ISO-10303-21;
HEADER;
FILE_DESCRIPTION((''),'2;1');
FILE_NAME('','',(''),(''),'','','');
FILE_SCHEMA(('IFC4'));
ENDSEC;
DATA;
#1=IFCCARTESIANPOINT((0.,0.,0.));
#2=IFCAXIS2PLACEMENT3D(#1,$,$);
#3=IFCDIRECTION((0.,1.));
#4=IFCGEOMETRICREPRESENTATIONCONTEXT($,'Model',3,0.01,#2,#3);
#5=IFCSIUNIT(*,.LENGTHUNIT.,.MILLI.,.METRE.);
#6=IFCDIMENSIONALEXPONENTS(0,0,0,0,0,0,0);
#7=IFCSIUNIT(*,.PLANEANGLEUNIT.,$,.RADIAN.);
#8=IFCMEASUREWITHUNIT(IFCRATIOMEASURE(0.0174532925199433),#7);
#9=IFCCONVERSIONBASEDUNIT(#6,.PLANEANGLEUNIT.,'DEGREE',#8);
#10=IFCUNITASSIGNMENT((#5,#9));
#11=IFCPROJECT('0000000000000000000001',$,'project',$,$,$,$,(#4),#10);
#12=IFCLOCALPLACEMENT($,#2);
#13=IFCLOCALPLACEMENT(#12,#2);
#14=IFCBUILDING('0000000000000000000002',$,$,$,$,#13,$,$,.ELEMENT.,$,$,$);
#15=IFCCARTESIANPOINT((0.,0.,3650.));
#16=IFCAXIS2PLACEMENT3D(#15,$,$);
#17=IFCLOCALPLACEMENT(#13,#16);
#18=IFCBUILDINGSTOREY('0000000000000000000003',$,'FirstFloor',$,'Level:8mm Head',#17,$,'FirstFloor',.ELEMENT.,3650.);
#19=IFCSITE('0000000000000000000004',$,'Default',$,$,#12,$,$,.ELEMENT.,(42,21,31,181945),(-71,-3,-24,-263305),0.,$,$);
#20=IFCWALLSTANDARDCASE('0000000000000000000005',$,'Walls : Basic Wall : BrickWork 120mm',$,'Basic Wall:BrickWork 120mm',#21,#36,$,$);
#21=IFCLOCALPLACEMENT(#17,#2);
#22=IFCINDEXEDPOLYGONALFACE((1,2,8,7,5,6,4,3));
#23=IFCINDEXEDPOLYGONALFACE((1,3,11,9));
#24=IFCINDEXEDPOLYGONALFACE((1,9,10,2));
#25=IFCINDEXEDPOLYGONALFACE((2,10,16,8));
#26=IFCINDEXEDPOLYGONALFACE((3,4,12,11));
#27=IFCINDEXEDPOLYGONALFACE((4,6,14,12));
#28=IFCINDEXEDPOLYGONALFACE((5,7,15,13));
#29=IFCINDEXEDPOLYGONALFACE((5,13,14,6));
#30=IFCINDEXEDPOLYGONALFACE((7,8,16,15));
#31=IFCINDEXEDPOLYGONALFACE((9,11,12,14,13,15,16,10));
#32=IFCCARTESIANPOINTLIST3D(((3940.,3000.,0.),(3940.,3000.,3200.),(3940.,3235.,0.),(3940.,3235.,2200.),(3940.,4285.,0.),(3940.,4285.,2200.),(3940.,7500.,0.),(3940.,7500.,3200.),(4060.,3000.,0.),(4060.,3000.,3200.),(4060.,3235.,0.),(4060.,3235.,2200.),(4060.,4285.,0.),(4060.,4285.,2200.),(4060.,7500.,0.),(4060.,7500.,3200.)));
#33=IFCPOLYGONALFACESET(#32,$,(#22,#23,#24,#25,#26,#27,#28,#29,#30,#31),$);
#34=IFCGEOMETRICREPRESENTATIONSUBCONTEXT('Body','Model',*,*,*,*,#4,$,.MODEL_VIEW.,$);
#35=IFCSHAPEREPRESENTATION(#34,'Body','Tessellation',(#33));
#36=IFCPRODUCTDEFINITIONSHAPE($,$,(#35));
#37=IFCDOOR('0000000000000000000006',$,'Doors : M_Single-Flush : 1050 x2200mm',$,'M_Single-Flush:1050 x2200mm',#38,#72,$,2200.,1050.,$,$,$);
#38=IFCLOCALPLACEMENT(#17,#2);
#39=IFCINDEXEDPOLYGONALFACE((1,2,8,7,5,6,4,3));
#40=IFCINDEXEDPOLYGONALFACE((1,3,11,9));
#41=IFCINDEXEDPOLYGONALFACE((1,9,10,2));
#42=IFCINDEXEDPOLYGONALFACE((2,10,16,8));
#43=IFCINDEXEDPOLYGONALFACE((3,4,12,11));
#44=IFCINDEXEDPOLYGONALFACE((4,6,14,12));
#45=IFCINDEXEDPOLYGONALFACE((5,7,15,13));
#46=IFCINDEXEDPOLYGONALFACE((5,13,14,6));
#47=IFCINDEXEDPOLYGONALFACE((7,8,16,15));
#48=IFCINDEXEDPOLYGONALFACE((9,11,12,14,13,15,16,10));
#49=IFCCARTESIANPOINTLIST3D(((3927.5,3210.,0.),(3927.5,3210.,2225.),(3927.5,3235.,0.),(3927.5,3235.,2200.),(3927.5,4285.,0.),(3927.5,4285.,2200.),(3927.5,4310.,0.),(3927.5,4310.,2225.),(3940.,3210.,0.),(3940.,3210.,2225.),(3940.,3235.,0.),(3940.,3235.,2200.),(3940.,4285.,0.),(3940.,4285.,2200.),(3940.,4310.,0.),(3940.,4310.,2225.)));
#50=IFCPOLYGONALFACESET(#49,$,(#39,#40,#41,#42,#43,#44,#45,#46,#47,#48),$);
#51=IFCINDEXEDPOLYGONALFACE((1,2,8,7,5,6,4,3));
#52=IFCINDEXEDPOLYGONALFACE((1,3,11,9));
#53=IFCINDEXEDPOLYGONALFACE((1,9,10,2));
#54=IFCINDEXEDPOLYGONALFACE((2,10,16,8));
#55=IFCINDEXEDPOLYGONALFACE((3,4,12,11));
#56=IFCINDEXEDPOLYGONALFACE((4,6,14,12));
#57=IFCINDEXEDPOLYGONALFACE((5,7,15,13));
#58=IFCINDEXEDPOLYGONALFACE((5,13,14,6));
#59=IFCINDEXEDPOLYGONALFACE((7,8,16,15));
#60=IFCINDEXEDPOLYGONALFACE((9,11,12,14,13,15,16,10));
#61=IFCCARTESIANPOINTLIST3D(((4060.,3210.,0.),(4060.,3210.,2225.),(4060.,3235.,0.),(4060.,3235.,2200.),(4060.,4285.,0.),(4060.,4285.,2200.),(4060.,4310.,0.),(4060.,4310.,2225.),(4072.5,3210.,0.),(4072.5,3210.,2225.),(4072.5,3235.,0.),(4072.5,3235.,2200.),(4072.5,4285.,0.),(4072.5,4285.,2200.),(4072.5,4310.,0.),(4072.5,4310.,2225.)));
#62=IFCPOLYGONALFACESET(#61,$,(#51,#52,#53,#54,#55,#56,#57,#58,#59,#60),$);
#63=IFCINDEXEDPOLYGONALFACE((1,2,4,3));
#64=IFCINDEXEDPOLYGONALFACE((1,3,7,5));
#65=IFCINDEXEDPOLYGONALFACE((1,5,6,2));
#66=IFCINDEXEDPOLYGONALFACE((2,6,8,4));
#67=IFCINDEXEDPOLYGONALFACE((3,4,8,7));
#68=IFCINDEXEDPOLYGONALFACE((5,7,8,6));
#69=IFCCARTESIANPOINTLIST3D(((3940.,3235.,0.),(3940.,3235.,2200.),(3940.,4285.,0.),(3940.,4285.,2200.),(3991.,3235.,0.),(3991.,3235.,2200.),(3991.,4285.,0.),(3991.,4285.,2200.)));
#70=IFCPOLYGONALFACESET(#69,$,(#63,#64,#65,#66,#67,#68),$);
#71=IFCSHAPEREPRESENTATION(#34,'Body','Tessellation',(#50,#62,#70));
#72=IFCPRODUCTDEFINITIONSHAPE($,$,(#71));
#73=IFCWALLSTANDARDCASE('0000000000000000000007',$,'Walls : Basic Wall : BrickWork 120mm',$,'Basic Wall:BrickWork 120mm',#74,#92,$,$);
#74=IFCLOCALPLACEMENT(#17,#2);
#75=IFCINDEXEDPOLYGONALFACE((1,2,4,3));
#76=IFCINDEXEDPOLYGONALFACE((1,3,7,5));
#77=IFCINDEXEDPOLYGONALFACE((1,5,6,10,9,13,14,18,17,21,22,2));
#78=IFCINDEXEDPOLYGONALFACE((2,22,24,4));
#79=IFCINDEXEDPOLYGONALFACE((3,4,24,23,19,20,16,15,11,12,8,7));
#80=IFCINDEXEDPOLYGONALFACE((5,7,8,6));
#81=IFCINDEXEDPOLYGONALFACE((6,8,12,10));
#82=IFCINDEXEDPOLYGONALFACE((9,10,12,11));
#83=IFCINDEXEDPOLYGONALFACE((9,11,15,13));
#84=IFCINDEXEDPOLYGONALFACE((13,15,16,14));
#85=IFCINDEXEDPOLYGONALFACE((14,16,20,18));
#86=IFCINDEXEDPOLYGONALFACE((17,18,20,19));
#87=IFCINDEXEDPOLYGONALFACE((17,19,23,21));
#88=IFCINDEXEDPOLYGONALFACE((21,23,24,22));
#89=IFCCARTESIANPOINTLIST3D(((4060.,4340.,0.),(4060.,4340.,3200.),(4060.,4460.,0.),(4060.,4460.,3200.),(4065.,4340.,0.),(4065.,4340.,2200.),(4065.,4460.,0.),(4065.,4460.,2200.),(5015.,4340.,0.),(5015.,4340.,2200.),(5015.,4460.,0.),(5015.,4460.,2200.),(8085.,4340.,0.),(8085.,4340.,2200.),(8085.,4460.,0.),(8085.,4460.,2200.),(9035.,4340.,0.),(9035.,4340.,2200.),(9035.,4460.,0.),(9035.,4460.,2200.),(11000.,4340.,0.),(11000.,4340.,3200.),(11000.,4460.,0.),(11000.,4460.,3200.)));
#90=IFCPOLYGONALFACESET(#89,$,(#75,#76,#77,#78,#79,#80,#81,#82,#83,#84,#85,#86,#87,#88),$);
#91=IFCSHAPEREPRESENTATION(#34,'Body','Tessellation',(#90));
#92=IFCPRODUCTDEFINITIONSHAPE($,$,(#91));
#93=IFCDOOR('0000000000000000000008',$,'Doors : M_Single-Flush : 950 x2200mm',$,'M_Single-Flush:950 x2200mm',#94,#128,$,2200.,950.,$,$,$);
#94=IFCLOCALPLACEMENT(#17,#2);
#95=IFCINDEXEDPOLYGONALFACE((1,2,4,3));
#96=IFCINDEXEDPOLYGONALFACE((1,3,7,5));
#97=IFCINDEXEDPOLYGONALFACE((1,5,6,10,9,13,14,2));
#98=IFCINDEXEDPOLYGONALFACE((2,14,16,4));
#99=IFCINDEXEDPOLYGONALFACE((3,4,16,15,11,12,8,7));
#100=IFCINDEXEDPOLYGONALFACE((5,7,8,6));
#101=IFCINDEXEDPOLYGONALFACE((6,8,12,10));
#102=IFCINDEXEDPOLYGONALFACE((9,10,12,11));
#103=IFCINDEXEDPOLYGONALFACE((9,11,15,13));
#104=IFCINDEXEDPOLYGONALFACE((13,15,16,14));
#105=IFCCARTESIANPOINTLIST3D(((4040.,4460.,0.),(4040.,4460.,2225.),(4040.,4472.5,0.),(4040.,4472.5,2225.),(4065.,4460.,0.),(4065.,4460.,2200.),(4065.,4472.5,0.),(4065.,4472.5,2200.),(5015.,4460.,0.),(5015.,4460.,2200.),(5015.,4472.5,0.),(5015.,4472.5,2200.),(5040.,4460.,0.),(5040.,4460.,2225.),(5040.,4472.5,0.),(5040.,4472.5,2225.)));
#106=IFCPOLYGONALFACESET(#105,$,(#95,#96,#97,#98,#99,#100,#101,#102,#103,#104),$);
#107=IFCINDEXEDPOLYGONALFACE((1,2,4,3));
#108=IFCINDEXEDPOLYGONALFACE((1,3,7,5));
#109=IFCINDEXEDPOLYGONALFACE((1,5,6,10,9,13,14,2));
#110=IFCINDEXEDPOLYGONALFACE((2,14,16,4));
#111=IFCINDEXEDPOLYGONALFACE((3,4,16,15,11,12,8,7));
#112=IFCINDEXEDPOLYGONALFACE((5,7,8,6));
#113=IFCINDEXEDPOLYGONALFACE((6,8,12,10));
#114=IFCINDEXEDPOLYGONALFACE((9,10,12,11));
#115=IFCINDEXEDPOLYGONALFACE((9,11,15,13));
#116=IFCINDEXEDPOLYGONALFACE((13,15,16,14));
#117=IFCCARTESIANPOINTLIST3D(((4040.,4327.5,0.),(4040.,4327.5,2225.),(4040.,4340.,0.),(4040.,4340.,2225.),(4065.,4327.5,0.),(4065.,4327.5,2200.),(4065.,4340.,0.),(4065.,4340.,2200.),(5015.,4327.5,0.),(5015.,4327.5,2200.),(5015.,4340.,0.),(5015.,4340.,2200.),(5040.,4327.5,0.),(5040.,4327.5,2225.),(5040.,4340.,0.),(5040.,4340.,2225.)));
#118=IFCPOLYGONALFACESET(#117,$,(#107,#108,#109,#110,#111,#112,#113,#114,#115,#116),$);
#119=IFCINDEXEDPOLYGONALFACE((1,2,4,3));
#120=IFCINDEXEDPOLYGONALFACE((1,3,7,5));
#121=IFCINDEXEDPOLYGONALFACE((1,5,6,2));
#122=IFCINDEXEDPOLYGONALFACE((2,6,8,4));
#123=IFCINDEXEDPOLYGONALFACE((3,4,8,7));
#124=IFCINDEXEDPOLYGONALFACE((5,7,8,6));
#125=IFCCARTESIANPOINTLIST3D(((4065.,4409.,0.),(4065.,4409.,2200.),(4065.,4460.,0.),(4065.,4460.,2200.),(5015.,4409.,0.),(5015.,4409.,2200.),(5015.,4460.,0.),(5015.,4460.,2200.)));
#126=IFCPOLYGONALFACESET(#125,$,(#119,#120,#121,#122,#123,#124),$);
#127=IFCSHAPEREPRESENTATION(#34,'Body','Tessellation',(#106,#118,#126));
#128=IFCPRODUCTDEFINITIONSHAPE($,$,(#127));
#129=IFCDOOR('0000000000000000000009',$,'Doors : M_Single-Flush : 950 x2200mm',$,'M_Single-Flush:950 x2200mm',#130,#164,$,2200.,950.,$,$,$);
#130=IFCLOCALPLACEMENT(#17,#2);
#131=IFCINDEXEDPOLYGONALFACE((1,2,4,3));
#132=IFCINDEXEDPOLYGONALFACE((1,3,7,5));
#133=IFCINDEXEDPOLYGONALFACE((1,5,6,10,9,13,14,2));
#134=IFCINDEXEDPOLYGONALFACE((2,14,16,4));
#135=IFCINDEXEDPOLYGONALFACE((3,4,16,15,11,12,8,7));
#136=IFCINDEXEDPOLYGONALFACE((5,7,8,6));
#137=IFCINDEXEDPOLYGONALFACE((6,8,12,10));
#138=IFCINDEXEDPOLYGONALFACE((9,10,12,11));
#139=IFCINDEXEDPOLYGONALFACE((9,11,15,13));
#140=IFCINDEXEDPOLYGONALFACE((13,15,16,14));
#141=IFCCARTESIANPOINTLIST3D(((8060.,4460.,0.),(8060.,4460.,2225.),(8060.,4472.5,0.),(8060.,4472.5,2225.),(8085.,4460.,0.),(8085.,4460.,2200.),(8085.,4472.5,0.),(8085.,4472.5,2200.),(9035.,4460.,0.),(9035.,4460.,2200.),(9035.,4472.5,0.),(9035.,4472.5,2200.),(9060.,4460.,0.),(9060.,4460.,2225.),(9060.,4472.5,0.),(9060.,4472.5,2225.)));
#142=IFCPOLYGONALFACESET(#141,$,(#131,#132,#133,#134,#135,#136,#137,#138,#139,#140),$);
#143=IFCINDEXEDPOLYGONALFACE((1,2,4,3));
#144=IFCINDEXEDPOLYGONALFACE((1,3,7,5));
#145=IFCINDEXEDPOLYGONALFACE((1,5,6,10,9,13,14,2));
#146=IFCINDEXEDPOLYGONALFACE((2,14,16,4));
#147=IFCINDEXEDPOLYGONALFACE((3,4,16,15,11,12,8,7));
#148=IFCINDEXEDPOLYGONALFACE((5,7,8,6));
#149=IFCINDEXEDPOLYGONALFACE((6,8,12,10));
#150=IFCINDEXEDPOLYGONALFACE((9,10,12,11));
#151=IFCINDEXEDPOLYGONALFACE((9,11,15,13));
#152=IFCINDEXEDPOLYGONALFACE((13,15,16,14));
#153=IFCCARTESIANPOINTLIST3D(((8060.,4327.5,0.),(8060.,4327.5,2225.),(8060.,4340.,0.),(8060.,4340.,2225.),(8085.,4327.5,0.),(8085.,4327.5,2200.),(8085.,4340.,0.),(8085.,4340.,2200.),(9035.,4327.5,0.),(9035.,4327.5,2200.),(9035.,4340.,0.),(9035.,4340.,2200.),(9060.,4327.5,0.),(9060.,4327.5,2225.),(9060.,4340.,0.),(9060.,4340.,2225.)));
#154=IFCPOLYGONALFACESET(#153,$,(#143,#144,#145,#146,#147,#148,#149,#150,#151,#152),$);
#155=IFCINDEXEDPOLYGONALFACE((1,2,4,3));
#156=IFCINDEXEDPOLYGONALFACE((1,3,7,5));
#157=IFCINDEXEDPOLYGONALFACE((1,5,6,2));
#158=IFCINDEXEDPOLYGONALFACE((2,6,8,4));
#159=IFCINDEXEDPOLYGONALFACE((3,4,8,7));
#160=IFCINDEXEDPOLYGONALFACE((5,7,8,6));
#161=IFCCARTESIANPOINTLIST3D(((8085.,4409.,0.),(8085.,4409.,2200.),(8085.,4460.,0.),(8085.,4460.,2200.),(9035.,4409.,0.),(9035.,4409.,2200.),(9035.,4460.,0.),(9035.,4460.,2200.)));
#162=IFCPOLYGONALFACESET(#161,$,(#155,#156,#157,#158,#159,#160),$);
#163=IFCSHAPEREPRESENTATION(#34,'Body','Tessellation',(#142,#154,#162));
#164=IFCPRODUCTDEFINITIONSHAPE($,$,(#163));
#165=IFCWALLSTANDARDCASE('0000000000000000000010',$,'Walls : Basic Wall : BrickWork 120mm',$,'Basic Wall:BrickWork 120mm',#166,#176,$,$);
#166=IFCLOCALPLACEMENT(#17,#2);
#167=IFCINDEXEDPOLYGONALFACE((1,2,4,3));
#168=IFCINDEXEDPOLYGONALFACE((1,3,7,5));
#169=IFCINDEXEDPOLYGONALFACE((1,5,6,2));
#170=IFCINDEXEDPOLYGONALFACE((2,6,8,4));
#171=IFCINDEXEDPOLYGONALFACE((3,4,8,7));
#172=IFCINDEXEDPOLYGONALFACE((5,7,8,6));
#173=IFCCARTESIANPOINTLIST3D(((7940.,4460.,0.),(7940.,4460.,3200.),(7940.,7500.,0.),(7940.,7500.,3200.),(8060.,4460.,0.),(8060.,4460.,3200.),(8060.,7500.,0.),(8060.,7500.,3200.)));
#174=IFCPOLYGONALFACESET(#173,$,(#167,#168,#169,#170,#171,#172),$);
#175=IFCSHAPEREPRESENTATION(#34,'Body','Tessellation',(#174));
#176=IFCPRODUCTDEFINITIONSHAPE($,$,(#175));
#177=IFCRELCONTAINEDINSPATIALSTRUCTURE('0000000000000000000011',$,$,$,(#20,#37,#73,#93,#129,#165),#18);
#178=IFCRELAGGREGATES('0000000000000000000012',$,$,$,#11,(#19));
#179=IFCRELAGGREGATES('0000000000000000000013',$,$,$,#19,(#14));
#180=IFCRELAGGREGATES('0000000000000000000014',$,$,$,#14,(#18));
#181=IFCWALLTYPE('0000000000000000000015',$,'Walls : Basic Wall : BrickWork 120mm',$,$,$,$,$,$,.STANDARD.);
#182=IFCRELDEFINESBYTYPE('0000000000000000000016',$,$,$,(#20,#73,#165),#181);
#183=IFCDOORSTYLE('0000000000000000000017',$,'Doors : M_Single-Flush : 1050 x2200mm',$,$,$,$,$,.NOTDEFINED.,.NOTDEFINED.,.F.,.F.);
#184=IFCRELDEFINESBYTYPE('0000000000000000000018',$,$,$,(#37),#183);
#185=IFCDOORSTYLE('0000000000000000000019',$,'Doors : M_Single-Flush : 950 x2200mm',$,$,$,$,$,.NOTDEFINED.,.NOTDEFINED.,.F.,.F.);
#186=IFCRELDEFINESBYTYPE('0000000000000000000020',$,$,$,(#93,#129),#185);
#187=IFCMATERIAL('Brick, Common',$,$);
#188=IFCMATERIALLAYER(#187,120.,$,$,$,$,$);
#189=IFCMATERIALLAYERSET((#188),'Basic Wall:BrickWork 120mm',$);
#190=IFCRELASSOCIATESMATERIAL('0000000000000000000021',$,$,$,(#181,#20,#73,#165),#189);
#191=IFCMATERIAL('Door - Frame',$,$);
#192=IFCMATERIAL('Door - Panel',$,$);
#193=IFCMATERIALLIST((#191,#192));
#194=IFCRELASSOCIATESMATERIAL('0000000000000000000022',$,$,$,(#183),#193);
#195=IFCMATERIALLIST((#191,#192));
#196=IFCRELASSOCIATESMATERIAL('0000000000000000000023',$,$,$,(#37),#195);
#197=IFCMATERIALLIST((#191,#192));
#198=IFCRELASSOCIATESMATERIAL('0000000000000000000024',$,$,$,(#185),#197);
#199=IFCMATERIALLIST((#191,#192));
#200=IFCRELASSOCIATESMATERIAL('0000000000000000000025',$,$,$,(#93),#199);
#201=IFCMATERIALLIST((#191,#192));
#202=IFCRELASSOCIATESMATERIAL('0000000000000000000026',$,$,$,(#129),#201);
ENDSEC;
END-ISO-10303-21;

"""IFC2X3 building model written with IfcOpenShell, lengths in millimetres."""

from ifc_helpers import new_model, entity, si_unit, converted_unit, direction, frame, frame_2d, origin, place, context, subcontext, project, spatial, polyline, rectangle, outline, extrude, source, transform, mapped, material, material_list, layer, layer_set, layer_usage, type_object, type_shapes, element, fill, save


model = new_model("IFC2X3")

# Units and contexts
model_context = context("Model", 3, precision=0.01, world=origin(), true_north=direction((0.0, 1.0)))
body_context = subcontext(model_context, "Body", "Model", "MODEL_VIEW")
ifc_project = project(units=[si_unit("LENGTHUNIT", "METRE", prefix="MILLI"), converted_unit("PLANEANGLEUNIT", "DEGREE", entity("IfcRatioMeasure", 0.0174532925199433), si_unit("PLANEANGLEUNIT", "RADIAN"), dimensions=[0, 0, 0, 0, 0, 0, 0])], contexts=[model_context])

# Site, building, storey
site_placement = place(None, origin())
site = spatial("IfcSite", under=ifc_project, at=site_placement, Name="Default", CompositionType="ELEMENT", RefLatitude=(42, 21, 31, 181945), RefLongitude=(-71, -3, -24, -263305), RefElevation=0.0)
building_placement = place(site_placement, origin())
building = spatial("IfcBuilding", under=site, at=building_placement, CompositionType="ELEMENT")
storey_placement = place(building_placement, frame((0.0, 0.0, 3650.0)))
storey = spatial("IfcBuildingStorey", under=building, at=storey_placement, Name="FirstFloor", ObjectType="Level:8mm Head", LongName="FirstFloor", CompositionType="ELEMENT", Elevation=3650.0)

# Wall, opening, door
ifc_material_1 = material(Name="Brick, Common")
ifc_layer_1 = layer(ifc_material_1, 120.0)
ifc_layer_set_1 = layer_set([ifc_layer_1], Name="Basic Wall:BrickWork 120mm")
ifc_layer_usage_1 = layer_usage(ifc_layer_set_1, "AXIS2", "NEGATIVE", 60.0)
wall_type = type_object("IfcWallType", Name="Walls : Basic Wall : BrickWork 120mm", PredefinedType="STANDARD", material=ifc_layer_set_1)
wall_1_placement = place(storey_placement, frame((4000.0, 7500.0, 0.0), z_axis=(0.0, 0.0, 1.0), x_axis=(0.0, -1.0, 0.0)))
wall_1 = element("IfcWallStandardCase", 1, at=wall_1_placement, inside=storey, type_object=wall_type, material=ifc_layer_usage_1, Name="Walls : Basic Wall : BrickWork 120mm", ObjectType="Basic Wall:BrickWork 120mm", context=body_context, shape_type="SweptSolid", body=[
    extrude(rectangle(XDim=4500.0, YDim=120.0, at=frame_2d((2250.0, 0.0), x_axis=(-1.0, 0.0))), origin(), (0.0, 0.0, 1.0), 3200.0),
])
opening_1_placement = place(wall_1_placement, frame((4265.0, 60.0, 0.0)))
opening_1 = element("IfcOpeningElement", 2, at=opening_1_placement, cuts=wall_1, ObjectType="Opening", context=body_context, shape_type="SweptSolid", body=[
    extrude(rectangle(XDim=1050.0, YDim=2200.0, at=frame_2d((1100.0, 525.0), x_axis=(0.0, -1.0))), frame((0.0, 0.0, 0.0), z_axis=(0.0, -1.0, 0.0), x_axis=(0.0, 0.0, 1.0)), (0.0, 0.0, 1.0), 120.0),
])
ifc_material_2 = material(Name="Door - Frame")
ifc_material_3 = material(Name="Door - Panel")
ifc_material_list_1 = material_list([ifc_material_2, ifc_material_3])
ifc_material_list_2 = material_list([ifc_material_2, ifc_material_3])
door_style_1 = type_object("IfcDoorStyle", Name="Doors : M_Single-Flush : 1050 x2200mm", ConstructionType="NOTDEFINED", OperationType="NOTDEFINED", ParameterTakesPrecedence=False, Sizeable=False, material=ifc_material_list_2)
shared_shape_1 = source(origin(), body_context, "Body", "SweptSolid", [
    extrude(outline(polyline([(-550.0, -1118.8), (550.0, -1118.8), (550.0, 1106.2), (525.0, 1106.2), (525.0, -1093.8), (-525.0, -1093.8), (-525.0, 1106.2), (-550.0, 1106.2), (-550.0, -1118.8)])), frame((525.0, 132.5, 1106.2), z_axis=(0.0, -1.0, 0.0), x_axis=(-1.0, 0.0, 0.0)), (0.0, 0.0, 1.0), 12.5),
    extrude(outline(polyline([(-1118.8, -550.0), (1106.2, -550.0), (1106.2, -525.0), (-1093.8, -525.0), (-1093.8, 525.0), (1106.2, 525.0), (1106.2, 550.0), (-1118.8, 550.0), (-1118.8, -550.0)])), frame((525.0, 0.0, 1106.2), z_axis=(0.0, -1.0, 0.0), x_axis=(0.0, 0.0, -1.0)), (0.0, 0.0, 1.0), 12.5),
    extrude(rectangle(XDim=1050.0, YDim=51.0, at=frame_2d((0.0, 0.0), x_axis=(1.0, 0.0))), frame((525.0, 94.5, 0.0)), (0.0, 0.0, 1.0), 2200.0),
])
type_shapes(door_style_1, [shared_shape_1])
door_1_placement = place(opening_1_placement, frame((0.0, 0.0, 0.0), z_axis=(0.0, 0.0, 1.0), x_axis=(-1.0, 0.0, 0.0)))
door_1 = element("IfcDoor", 3, at=door_1_placement, inside=storey, type_object=door_style_1, material=ifc_material_list_1, Name="Doors : M_Single-Flush : 1050 x2200mm", ObjectType="M_Single-Flush:1050 x2200mm", OverallHeight=2200.0, OverallWidth=1050.0, context=body_context, shape_type="MappedRepresentation", body=[
    mapped(shared_shape_1, transform((0.0, 0.0, 0.0), scale=1.0)),
])
fill(opening_1, door_1)

# Wall, openings, doors
ifc_layer_usage_2 = layer_usage(ifc_layer_set_1, "AXIS2", "NEGATIVE", 60.0)
wall_2_placement = place(storey_placement, frame((11000.0, 4400.0, 0.0), z_axis=(0.0, 0.0, 1.0), x_axis=(-1.0, 0.0, 0.0)))
wall_2 = element("IfcWallStandardCase", 4, at=wall_2_placement, inside=storey, type_object=wall_type, material=ifc_layer_usage_2, Name="Walls : Basic Wall : BrickWork 120mm", ObjectType="Basic Wall:BrickWork 120mm", context=body_context, shape_type="SweptSolid", body=[
    extrude(rectangle(XDim=6940.0, YDim=120.0, at=frame_2d((3470.0, 0.0), x_axis=(-1.0, 0.0))), origin(), (0.0, 0.0, 1.0), 3200.0),
])
opening_2_placement = place(wall_2_placement, frame((6935.0, 60.0, 0.0)))
opening_2 = element("IfcOpeningElement", 5, at=opening_2_placement, cuts=wall_2, ObjectType="Opening", context=body_context, shape_type="SweptSolid", body=[
    extrude(rectangle(XDim=950.0, YDim=2200.0, at=frame_2d((1100.0, 475.0), x_axis=(0.0, -1.0))), frame((0.0, 0.0, 0.0), z_axis=(0.0, -1.0, 0.0), x_axis=(0.0, 0.0, 1.0)), (0.0, 0.0, 1.0), 120.0),
])
opening_3_placement = place(wall_2_placement, frame((2915.0, 60.0, 0.0)))
opening_3 = element("IfcOpeningElement", 6, at=opening_3_placement, cuts=wall_2, ObjectType="Opening", context=body_context, shape_type="SweptSolid", body=[
    extrude(rectangle(XDim=950.0, YDim=2200.0, at=frame_2d((1100.0, 475.0), x_axis=(0.0, -1.0))), frame((0.0, 0.0, 0.0), z_axis=(0.0, -1.0, 0.0), x_axis=(0.0, 0.0, 1.0)), (0.0, 0.0, 1.0), 120.0),
])
ifc_material_list_3 = material_list([ifc_material_2, ifc_material_3])
ifc_material_list_4 = material_list([ifc_material_2, ifc_material_3])
door_style_2 = type_object("IfcDoorStyle", Name="Doors : M_Single-Flush : 950 x2200mm", ConstructionType="NOTDEFINED", OperationType="NOTDEFINED", ParameterTakesPrecedence=False, Sizeable=False, material=ifc_material_list_4)
shared_shape_2 = source(origin(), body_context, "Body", "SweptSolid", [
    extrude(outline(polyline([(-500.0, -1118.8), (500.0, -1118.8), (500.0, 1106.2), (475.0, 1106.2), (475.0, -1093.8), (-475.0, -1093.8), (-475.0, 1106.2), (-500.0, 1106.2), (-500.0, -1118.8)])), frame((475.0, 132.5, 1106.2), z_axis=(0.0, -1.0, 0.0), x_axis=(-1.0, 0.0, 0.0)), (0.0, 0.0, 1.0), 12.5),
    extrude(outline(polyline([(-1118.8, -500.0), (1106.2, -500.0), (1106.2, -475.0), (-1093.8, -475.0), (-1093.8, 475.0), (1106.2, 475.0), (1106.2, 500.0), (-1118.8, 500.0), (-1118.8, -500.0)])), frame((475.0, 0.0, 1106.2), z_axis=(0.0, -1.0, 0.0), x_axis=(0.0, 0.0, -1.0)), (0.0, 0.0, 1.0), 12.5),
    extrude(rectangle(XDim=950.0, YDim=51.0, at=frame_2d((0.0, 0.0), x_axis=(1.0, 0.0))), frame((475.0, 94.5, 0.0)), (0.0, 0.0, 1.0), 2200.0),
])
type_shapes(door_style_2, [shared_shape_2])
door_2_placement = place(opening_2_placement, frame((0.0, 0.0, 0.0), z_axis=(0.0, 0.0, 1.0), x_axis=(-1.0, 0.0, 0.0)))
door_2 = element("IfcDoor", 7, at=door_2_placement, inside=storey, type_object=door_style_2, material=ifc_material_list_3, Name="Doors : M_Single-Flush : 950 x2200mm", ObjectType="M_Single-Flush:950 x2200mm", OverallHeight=2200.0, OverallWidth=950.0, context=body_context, shape_type="MappedRepresentation", body=[
    mapped(shared_shape_2, transform((0.0, 0.0, 0.0), scale=1.0)),
])
fill(opening_2, door_2)
ifc_material_list_5 = material_list([ifc_material_2, ifc_material_3])
door_3_placement = place(opening_3_placement, frame((0.0, 0.0, 0.0), z_axis=(0.0, 0.0, 1.0), x_axis=(-1.0, 0.0, 0.0)))
door_3 = element("IfcDoor", 8, at=door_3_placement, inside=storey, type_object=door_style_2, material=ifc_material_list_5, Name="Doors : M_Single-Flush : 950 x2200mm", ObjectType="M_Single-Flush:950 x2200mm", OverallHeight=2200.0, OverallWidth=950.0, context=body_context, shape_type="MappedRepresentation", body=[
    mapped(shared_shape_2, transform((0.0, 0.0, 0.0), scale=1.0)),
])
fill(opening_3, door_3)

# Wall
ifc_layer_usage_3 = layer_usage(ifc_layer_set_1, "AXIS2", "NEGATIVE", 60.0)
wall_3_placement = place(storey_placement, frame((8000.0, 7500.0, 0.0), z_axis=(0.0, 0.0, 1.0), x_axis=(0.0, -1.0, 0.0)))
element("IfcWallStandardCase", 9, at=wall_3_placement, inside=storey, type_object=wall_type, material=ifc_layer_usage_3, Name="Walls : Basic Wall : BrickWork 120mm", ObjectType="Basic Wall:BrickWork 120mm", context=body_context, shape_type="SweptSolid", body=[
    extrude(rectangle(XDim=3040.0, YDim=120.0, at=frame_2d((1520.0, 0.0), x_axis=(-1.0, 0.0))), origin(), (0.0, 0.0, 1.0), 3200.0),
])

save(model, "model.ifc")
